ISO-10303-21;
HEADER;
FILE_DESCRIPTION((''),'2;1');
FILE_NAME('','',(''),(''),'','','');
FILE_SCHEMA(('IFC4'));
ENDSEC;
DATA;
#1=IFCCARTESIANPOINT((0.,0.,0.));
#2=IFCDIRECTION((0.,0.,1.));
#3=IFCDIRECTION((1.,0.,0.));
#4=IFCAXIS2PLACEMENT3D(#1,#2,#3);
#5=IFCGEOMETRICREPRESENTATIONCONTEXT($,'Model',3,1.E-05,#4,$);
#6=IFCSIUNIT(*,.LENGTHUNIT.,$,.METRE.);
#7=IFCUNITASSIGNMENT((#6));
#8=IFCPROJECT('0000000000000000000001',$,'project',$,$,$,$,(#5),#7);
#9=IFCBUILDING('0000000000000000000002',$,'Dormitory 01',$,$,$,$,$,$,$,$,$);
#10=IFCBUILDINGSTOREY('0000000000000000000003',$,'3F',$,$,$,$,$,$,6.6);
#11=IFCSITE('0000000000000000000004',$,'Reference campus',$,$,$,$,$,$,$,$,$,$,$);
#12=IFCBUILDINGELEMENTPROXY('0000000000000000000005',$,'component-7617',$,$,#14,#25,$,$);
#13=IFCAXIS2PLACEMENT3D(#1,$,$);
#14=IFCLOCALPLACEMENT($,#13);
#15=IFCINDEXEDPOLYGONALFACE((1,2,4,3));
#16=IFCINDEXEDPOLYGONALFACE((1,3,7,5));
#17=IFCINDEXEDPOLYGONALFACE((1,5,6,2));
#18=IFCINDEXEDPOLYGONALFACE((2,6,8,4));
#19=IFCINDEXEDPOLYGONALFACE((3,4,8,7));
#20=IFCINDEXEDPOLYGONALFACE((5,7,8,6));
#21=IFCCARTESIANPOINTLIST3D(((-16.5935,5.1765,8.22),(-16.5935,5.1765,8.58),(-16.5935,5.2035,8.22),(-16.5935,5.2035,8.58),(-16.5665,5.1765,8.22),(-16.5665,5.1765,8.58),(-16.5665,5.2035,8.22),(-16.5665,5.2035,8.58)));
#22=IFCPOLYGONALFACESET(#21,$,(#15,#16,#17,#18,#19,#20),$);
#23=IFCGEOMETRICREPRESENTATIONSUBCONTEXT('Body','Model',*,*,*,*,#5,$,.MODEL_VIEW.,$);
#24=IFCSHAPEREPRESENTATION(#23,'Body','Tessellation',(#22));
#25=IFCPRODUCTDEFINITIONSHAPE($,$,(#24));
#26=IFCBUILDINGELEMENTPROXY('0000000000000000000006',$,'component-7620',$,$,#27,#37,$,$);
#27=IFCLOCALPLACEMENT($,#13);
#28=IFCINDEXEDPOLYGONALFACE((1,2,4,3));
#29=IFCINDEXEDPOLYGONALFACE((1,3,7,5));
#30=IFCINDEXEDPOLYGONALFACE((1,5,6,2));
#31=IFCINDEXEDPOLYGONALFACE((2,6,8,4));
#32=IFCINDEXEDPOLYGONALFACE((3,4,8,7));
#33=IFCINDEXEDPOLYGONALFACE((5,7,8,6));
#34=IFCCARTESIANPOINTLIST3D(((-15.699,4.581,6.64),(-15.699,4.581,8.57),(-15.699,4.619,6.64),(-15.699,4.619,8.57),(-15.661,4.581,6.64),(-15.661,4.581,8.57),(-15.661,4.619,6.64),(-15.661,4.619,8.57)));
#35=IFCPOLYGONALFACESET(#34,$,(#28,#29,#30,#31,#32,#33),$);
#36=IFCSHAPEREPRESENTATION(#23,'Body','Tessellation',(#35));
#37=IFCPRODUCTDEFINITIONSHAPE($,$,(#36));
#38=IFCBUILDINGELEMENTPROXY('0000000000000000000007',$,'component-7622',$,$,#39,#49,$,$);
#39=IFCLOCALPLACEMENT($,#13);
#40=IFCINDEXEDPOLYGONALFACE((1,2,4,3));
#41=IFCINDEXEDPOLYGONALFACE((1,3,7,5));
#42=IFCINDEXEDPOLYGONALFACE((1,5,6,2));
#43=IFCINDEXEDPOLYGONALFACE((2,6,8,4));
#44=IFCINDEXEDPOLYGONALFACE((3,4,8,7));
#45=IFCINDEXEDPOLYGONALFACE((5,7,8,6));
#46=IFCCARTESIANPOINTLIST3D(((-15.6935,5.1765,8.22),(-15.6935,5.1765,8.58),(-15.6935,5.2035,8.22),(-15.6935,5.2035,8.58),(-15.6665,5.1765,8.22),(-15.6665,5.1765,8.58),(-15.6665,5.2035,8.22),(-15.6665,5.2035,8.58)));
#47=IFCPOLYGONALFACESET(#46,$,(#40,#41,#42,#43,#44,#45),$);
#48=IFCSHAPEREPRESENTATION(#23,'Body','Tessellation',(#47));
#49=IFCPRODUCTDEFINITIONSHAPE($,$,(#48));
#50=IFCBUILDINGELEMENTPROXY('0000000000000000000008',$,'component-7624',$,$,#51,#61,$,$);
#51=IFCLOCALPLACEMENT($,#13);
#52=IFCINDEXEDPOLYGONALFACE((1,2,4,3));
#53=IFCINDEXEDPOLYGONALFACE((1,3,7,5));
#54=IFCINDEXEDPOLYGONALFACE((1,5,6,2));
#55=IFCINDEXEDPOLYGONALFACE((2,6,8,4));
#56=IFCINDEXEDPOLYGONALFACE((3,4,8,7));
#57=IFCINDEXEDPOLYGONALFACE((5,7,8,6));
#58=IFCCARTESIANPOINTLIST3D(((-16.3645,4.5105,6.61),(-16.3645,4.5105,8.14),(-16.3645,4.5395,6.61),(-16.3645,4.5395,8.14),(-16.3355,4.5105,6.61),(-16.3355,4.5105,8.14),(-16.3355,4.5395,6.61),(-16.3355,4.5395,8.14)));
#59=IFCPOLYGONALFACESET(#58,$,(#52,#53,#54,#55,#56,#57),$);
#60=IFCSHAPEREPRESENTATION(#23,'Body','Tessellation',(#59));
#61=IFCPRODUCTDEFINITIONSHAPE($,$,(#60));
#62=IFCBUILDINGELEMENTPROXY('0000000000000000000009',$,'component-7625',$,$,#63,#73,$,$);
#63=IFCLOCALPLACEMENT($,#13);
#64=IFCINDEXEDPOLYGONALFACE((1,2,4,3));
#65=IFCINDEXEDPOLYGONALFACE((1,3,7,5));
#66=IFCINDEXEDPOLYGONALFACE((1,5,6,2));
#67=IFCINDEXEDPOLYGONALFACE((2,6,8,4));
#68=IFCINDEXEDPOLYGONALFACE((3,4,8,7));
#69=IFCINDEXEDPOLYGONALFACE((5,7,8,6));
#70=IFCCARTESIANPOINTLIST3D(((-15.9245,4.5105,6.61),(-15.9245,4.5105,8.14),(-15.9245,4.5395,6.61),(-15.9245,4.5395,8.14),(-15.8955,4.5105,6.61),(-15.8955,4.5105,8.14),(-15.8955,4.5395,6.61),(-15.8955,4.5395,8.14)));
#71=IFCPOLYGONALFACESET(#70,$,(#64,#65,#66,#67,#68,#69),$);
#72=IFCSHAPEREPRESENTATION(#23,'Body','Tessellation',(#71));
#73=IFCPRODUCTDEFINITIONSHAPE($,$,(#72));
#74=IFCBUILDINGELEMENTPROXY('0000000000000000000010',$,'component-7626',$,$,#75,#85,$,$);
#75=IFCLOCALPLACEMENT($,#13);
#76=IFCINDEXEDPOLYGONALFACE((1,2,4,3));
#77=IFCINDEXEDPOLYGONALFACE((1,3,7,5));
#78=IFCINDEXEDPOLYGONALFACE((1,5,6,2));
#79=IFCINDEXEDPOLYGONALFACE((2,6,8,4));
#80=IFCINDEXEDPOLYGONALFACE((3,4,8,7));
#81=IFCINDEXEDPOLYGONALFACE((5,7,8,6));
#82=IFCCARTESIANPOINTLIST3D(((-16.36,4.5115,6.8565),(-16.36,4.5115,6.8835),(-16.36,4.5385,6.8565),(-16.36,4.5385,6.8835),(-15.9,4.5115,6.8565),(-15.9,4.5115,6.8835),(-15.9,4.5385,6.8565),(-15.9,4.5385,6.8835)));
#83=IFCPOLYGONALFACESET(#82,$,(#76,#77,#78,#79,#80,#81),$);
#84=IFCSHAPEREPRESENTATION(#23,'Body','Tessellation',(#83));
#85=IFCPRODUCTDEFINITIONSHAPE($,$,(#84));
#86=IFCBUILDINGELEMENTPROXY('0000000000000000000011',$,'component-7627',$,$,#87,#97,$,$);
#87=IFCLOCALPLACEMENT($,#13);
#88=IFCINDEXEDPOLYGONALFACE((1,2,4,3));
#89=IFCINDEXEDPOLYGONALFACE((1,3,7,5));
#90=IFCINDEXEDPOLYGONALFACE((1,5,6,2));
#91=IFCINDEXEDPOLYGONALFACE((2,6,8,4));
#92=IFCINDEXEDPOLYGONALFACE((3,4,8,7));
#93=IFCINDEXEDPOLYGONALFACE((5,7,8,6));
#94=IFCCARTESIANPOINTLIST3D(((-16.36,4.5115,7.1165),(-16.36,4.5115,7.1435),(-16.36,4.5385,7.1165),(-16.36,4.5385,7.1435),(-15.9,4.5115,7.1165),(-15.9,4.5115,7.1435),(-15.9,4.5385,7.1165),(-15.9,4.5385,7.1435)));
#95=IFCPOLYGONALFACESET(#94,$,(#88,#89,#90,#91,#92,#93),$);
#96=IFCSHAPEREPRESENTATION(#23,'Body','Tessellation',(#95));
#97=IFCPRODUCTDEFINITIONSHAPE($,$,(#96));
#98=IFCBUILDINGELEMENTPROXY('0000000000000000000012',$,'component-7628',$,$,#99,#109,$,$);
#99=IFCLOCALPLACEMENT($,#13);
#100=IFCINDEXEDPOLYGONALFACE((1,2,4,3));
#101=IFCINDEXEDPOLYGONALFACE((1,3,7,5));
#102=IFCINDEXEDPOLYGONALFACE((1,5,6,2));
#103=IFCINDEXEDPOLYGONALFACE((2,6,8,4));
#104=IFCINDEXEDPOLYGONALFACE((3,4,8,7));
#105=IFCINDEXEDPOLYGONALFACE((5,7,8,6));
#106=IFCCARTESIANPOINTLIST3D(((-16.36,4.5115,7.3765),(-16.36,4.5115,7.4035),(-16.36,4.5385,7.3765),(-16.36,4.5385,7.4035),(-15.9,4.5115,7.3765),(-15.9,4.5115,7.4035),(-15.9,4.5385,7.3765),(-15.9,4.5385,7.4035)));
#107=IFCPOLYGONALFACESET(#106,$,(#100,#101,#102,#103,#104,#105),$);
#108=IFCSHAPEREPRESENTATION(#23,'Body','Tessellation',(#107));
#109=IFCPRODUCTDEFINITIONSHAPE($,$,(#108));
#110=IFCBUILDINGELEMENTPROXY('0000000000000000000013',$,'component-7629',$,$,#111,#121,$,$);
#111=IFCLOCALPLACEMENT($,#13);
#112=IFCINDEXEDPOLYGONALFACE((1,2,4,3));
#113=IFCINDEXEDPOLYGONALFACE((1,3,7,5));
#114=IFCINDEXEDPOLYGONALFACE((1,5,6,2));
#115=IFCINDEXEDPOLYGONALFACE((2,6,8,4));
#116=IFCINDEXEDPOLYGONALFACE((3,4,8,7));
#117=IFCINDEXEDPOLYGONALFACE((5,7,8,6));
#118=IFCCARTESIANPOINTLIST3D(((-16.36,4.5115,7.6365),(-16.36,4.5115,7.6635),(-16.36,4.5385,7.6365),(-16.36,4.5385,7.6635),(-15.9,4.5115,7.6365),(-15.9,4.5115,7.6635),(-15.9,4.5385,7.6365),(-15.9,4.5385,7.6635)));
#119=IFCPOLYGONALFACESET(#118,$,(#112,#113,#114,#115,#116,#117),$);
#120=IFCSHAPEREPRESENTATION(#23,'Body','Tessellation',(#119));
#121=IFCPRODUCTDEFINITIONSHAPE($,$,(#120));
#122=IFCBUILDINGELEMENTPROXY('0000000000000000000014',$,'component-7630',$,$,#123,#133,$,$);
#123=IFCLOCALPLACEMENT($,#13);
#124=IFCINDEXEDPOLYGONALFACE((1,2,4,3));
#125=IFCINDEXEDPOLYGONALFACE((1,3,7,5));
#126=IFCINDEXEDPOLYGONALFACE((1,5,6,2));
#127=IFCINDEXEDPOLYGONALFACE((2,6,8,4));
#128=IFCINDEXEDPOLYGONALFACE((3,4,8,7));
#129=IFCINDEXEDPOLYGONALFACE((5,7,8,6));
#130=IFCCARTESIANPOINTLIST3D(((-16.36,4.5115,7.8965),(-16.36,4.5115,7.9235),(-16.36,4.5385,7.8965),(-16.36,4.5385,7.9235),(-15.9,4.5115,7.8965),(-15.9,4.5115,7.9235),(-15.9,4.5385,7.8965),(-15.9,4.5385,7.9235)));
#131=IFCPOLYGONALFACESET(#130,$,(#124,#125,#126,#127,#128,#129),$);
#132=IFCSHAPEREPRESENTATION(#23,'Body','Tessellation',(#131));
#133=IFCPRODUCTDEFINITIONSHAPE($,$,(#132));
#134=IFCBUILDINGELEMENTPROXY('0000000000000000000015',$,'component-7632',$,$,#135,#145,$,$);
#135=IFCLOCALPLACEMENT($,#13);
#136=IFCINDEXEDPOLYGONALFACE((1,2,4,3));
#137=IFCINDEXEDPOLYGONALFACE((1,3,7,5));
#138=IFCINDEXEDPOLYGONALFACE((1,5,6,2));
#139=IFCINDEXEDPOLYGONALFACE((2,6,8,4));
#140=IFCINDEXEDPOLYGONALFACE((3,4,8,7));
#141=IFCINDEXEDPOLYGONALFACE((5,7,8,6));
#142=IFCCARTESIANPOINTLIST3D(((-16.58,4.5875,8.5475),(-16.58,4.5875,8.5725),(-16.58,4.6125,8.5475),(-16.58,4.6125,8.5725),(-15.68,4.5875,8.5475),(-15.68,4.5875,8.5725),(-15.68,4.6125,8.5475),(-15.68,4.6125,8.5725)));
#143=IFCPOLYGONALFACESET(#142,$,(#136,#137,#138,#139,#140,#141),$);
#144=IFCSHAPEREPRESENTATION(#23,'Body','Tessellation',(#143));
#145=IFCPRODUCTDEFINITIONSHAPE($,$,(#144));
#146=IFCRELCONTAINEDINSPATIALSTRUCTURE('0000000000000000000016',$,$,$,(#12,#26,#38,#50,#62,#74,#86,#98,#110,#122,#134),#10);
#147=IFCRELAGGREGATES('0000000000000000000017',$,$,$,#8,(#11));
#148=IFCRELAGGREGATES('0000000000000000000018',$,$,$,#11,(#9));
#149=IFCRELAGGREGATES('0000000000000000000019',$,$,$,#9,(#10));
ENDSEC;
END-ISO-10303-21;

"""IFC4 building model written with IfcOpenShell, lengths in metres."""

from ifc_helpers import new_model, si_unit, frame, origin, origin_with_axes, origin_2d, place, context, subcontext, project, spatial, rectangle, extrude, element, save


model = new_model("IFC4")

# Units and contexts
model_context = context("Model", 3, precision=1e-05, world=origin_with_axes())
body_context = subcontext(model_context, "Body", "Model", "MODEL_VIEW")
ifc_project = project(units=[si_unit("LENGTHUNIT", "METRE")], contexts=[model_context])

# Site, building, storey
site = spatial("IfcSite", under=ifc_project, Name="Reference campus")
building = spatial("IfcBuilding", under=site, Name="Dormitory 01")
storey = spatial("IfcBuildingStorey", under=building, Name="3F", Elevation=6.6)

# Building element proxies
proxy_1_placement = place(None, frame((-16.58, 5.19, 8.22), z_axis=(0.0, 0.0, 1.0), x_axis=(1.0, 0.0, 0.0)))
element("IfcBuildingElementProxy", 1, at=proxy_1_placement, inside=storey, Name="component-7617", context=body_context, shape_type="SweptSolid", body=[
    extrude(rectangle(XDim=0.027, YDim=0.027, at=origin_2d()), origin(), (0.0, 0.0, 1.0), 0.36),
])
proxy_2_placement = place(None, frame((-15.68, 4.6, 6.64), z_axis=(0.0, 0.0, 1.0), x_axis=(1.0, 0.0, 0.0)))
element("IfcBuildingElementProxy", 2, at=proxy_2_placement, inside=storey, Name="component-7620", context=body_context, shape_type="SweptSolid", body=[
    extrude(rectangle(XDim=0.038, YDim=0.038, at=origin_2d()), origin(), (0.0, 0.0, 1.0), 1.93),
])
proxy_3_placement = place(None, frame((-15.68, 5.19, 8.22), z_axis=(0.0, 0.0, 1.0), x_axis=(1.0, 0.0, 0.0)))
element("IfcBuildingElementProxy", 3, at=proxy_3_placement, inside=storey, Name="component-7622", context=body_context, shape_type="SweptSolid", body=[
    extrude(rectangle(XDim=0.027, YDim=0.027, at=origin_2d()), origin(), (0.0, 0.0, 1.0), 0.36),
])
for number, where, z_axis, x_axis, name in (
    (4, (-16.35, 4.525, 6.61), (0.0, 0.0, 1.0), (1.0, 0.0, 0.0), "component-7624"),
    (5, (-15.91, 4.525, 6.61), (0.0, 0.0, 1.0), (1.0, 0.0, 0.0), "component-7625"),
):
    element("IfcBuildingElementProxy", number, at=place(None, frame(where, z_axis=z_axis, x_axis=x_axis)), inside=storey, Name=name, context=body_context, shape_type="SweptSolid", body=[
        extrude(rectangle(XDim=0.029, YDim=0.029, at=origin_2d()), origin(), (0.0, 0.0, 1.0), 1.53),
    ])
for number, where, z_axis, x_axis, name in (
    (6, (-16.13, 4.525, 6.8565), (0.0, 0.0, 1.0), (1.0, 0.0, 0.0), "component-7626"),
    (7, (-16.13, 4.525, 7.1165), (0.0, 0.0, 1.0), (1.0, 0.0, 0.0), "component-7627"),
    (8, (-16.13, 4.525, 7.3765), (0.0, 0.0, 1.0), (1.0, 0.0, 0.0), "component-7628"),
    (9, (-16.13, 4.525, 7.6365), (0.0, 0.0, 1.0), (1.0, 0.0, 0.0), "component-7629"),
    (10, (-16.13, 4.525, 7.8965), (0.0, 0.0, 1.0), (1.0, 0.0, 0.0), "component-7630"),
):
    element("IfcBuildingElementProxy", number, at=place(None, frame(where, z_axis=z_axis, x_axis=x_axis)), inside=storey, Name=name, context=body_context, shape_type="SweptSolid", body=[
        extrude(rectangle(XDim=0.46, YDim=0.027, at=origin_2d()), origin(), (0.0, 0.0, 1.0), 0.027),
    ])
proxy_4_placement = place(None, frame((-16.13, 4.6, 8.5475), z_axis=(0.0, 0.0, 1.0), x_axis=(1.0, 0.0, 0.0)))
element("IfcBuildingElementProxy", 11, at=proxy_4_placement, inside=storey, Name="component-7632", context=body_context, shape_type="SweptSolid", body=[
    extrude(rectangle(XDim=0.9, YDim=0.025, at=origin_2d()), origin(), (0.0, 0.0, 1.0), 0.025),
])

save(model, "model.ifc")
